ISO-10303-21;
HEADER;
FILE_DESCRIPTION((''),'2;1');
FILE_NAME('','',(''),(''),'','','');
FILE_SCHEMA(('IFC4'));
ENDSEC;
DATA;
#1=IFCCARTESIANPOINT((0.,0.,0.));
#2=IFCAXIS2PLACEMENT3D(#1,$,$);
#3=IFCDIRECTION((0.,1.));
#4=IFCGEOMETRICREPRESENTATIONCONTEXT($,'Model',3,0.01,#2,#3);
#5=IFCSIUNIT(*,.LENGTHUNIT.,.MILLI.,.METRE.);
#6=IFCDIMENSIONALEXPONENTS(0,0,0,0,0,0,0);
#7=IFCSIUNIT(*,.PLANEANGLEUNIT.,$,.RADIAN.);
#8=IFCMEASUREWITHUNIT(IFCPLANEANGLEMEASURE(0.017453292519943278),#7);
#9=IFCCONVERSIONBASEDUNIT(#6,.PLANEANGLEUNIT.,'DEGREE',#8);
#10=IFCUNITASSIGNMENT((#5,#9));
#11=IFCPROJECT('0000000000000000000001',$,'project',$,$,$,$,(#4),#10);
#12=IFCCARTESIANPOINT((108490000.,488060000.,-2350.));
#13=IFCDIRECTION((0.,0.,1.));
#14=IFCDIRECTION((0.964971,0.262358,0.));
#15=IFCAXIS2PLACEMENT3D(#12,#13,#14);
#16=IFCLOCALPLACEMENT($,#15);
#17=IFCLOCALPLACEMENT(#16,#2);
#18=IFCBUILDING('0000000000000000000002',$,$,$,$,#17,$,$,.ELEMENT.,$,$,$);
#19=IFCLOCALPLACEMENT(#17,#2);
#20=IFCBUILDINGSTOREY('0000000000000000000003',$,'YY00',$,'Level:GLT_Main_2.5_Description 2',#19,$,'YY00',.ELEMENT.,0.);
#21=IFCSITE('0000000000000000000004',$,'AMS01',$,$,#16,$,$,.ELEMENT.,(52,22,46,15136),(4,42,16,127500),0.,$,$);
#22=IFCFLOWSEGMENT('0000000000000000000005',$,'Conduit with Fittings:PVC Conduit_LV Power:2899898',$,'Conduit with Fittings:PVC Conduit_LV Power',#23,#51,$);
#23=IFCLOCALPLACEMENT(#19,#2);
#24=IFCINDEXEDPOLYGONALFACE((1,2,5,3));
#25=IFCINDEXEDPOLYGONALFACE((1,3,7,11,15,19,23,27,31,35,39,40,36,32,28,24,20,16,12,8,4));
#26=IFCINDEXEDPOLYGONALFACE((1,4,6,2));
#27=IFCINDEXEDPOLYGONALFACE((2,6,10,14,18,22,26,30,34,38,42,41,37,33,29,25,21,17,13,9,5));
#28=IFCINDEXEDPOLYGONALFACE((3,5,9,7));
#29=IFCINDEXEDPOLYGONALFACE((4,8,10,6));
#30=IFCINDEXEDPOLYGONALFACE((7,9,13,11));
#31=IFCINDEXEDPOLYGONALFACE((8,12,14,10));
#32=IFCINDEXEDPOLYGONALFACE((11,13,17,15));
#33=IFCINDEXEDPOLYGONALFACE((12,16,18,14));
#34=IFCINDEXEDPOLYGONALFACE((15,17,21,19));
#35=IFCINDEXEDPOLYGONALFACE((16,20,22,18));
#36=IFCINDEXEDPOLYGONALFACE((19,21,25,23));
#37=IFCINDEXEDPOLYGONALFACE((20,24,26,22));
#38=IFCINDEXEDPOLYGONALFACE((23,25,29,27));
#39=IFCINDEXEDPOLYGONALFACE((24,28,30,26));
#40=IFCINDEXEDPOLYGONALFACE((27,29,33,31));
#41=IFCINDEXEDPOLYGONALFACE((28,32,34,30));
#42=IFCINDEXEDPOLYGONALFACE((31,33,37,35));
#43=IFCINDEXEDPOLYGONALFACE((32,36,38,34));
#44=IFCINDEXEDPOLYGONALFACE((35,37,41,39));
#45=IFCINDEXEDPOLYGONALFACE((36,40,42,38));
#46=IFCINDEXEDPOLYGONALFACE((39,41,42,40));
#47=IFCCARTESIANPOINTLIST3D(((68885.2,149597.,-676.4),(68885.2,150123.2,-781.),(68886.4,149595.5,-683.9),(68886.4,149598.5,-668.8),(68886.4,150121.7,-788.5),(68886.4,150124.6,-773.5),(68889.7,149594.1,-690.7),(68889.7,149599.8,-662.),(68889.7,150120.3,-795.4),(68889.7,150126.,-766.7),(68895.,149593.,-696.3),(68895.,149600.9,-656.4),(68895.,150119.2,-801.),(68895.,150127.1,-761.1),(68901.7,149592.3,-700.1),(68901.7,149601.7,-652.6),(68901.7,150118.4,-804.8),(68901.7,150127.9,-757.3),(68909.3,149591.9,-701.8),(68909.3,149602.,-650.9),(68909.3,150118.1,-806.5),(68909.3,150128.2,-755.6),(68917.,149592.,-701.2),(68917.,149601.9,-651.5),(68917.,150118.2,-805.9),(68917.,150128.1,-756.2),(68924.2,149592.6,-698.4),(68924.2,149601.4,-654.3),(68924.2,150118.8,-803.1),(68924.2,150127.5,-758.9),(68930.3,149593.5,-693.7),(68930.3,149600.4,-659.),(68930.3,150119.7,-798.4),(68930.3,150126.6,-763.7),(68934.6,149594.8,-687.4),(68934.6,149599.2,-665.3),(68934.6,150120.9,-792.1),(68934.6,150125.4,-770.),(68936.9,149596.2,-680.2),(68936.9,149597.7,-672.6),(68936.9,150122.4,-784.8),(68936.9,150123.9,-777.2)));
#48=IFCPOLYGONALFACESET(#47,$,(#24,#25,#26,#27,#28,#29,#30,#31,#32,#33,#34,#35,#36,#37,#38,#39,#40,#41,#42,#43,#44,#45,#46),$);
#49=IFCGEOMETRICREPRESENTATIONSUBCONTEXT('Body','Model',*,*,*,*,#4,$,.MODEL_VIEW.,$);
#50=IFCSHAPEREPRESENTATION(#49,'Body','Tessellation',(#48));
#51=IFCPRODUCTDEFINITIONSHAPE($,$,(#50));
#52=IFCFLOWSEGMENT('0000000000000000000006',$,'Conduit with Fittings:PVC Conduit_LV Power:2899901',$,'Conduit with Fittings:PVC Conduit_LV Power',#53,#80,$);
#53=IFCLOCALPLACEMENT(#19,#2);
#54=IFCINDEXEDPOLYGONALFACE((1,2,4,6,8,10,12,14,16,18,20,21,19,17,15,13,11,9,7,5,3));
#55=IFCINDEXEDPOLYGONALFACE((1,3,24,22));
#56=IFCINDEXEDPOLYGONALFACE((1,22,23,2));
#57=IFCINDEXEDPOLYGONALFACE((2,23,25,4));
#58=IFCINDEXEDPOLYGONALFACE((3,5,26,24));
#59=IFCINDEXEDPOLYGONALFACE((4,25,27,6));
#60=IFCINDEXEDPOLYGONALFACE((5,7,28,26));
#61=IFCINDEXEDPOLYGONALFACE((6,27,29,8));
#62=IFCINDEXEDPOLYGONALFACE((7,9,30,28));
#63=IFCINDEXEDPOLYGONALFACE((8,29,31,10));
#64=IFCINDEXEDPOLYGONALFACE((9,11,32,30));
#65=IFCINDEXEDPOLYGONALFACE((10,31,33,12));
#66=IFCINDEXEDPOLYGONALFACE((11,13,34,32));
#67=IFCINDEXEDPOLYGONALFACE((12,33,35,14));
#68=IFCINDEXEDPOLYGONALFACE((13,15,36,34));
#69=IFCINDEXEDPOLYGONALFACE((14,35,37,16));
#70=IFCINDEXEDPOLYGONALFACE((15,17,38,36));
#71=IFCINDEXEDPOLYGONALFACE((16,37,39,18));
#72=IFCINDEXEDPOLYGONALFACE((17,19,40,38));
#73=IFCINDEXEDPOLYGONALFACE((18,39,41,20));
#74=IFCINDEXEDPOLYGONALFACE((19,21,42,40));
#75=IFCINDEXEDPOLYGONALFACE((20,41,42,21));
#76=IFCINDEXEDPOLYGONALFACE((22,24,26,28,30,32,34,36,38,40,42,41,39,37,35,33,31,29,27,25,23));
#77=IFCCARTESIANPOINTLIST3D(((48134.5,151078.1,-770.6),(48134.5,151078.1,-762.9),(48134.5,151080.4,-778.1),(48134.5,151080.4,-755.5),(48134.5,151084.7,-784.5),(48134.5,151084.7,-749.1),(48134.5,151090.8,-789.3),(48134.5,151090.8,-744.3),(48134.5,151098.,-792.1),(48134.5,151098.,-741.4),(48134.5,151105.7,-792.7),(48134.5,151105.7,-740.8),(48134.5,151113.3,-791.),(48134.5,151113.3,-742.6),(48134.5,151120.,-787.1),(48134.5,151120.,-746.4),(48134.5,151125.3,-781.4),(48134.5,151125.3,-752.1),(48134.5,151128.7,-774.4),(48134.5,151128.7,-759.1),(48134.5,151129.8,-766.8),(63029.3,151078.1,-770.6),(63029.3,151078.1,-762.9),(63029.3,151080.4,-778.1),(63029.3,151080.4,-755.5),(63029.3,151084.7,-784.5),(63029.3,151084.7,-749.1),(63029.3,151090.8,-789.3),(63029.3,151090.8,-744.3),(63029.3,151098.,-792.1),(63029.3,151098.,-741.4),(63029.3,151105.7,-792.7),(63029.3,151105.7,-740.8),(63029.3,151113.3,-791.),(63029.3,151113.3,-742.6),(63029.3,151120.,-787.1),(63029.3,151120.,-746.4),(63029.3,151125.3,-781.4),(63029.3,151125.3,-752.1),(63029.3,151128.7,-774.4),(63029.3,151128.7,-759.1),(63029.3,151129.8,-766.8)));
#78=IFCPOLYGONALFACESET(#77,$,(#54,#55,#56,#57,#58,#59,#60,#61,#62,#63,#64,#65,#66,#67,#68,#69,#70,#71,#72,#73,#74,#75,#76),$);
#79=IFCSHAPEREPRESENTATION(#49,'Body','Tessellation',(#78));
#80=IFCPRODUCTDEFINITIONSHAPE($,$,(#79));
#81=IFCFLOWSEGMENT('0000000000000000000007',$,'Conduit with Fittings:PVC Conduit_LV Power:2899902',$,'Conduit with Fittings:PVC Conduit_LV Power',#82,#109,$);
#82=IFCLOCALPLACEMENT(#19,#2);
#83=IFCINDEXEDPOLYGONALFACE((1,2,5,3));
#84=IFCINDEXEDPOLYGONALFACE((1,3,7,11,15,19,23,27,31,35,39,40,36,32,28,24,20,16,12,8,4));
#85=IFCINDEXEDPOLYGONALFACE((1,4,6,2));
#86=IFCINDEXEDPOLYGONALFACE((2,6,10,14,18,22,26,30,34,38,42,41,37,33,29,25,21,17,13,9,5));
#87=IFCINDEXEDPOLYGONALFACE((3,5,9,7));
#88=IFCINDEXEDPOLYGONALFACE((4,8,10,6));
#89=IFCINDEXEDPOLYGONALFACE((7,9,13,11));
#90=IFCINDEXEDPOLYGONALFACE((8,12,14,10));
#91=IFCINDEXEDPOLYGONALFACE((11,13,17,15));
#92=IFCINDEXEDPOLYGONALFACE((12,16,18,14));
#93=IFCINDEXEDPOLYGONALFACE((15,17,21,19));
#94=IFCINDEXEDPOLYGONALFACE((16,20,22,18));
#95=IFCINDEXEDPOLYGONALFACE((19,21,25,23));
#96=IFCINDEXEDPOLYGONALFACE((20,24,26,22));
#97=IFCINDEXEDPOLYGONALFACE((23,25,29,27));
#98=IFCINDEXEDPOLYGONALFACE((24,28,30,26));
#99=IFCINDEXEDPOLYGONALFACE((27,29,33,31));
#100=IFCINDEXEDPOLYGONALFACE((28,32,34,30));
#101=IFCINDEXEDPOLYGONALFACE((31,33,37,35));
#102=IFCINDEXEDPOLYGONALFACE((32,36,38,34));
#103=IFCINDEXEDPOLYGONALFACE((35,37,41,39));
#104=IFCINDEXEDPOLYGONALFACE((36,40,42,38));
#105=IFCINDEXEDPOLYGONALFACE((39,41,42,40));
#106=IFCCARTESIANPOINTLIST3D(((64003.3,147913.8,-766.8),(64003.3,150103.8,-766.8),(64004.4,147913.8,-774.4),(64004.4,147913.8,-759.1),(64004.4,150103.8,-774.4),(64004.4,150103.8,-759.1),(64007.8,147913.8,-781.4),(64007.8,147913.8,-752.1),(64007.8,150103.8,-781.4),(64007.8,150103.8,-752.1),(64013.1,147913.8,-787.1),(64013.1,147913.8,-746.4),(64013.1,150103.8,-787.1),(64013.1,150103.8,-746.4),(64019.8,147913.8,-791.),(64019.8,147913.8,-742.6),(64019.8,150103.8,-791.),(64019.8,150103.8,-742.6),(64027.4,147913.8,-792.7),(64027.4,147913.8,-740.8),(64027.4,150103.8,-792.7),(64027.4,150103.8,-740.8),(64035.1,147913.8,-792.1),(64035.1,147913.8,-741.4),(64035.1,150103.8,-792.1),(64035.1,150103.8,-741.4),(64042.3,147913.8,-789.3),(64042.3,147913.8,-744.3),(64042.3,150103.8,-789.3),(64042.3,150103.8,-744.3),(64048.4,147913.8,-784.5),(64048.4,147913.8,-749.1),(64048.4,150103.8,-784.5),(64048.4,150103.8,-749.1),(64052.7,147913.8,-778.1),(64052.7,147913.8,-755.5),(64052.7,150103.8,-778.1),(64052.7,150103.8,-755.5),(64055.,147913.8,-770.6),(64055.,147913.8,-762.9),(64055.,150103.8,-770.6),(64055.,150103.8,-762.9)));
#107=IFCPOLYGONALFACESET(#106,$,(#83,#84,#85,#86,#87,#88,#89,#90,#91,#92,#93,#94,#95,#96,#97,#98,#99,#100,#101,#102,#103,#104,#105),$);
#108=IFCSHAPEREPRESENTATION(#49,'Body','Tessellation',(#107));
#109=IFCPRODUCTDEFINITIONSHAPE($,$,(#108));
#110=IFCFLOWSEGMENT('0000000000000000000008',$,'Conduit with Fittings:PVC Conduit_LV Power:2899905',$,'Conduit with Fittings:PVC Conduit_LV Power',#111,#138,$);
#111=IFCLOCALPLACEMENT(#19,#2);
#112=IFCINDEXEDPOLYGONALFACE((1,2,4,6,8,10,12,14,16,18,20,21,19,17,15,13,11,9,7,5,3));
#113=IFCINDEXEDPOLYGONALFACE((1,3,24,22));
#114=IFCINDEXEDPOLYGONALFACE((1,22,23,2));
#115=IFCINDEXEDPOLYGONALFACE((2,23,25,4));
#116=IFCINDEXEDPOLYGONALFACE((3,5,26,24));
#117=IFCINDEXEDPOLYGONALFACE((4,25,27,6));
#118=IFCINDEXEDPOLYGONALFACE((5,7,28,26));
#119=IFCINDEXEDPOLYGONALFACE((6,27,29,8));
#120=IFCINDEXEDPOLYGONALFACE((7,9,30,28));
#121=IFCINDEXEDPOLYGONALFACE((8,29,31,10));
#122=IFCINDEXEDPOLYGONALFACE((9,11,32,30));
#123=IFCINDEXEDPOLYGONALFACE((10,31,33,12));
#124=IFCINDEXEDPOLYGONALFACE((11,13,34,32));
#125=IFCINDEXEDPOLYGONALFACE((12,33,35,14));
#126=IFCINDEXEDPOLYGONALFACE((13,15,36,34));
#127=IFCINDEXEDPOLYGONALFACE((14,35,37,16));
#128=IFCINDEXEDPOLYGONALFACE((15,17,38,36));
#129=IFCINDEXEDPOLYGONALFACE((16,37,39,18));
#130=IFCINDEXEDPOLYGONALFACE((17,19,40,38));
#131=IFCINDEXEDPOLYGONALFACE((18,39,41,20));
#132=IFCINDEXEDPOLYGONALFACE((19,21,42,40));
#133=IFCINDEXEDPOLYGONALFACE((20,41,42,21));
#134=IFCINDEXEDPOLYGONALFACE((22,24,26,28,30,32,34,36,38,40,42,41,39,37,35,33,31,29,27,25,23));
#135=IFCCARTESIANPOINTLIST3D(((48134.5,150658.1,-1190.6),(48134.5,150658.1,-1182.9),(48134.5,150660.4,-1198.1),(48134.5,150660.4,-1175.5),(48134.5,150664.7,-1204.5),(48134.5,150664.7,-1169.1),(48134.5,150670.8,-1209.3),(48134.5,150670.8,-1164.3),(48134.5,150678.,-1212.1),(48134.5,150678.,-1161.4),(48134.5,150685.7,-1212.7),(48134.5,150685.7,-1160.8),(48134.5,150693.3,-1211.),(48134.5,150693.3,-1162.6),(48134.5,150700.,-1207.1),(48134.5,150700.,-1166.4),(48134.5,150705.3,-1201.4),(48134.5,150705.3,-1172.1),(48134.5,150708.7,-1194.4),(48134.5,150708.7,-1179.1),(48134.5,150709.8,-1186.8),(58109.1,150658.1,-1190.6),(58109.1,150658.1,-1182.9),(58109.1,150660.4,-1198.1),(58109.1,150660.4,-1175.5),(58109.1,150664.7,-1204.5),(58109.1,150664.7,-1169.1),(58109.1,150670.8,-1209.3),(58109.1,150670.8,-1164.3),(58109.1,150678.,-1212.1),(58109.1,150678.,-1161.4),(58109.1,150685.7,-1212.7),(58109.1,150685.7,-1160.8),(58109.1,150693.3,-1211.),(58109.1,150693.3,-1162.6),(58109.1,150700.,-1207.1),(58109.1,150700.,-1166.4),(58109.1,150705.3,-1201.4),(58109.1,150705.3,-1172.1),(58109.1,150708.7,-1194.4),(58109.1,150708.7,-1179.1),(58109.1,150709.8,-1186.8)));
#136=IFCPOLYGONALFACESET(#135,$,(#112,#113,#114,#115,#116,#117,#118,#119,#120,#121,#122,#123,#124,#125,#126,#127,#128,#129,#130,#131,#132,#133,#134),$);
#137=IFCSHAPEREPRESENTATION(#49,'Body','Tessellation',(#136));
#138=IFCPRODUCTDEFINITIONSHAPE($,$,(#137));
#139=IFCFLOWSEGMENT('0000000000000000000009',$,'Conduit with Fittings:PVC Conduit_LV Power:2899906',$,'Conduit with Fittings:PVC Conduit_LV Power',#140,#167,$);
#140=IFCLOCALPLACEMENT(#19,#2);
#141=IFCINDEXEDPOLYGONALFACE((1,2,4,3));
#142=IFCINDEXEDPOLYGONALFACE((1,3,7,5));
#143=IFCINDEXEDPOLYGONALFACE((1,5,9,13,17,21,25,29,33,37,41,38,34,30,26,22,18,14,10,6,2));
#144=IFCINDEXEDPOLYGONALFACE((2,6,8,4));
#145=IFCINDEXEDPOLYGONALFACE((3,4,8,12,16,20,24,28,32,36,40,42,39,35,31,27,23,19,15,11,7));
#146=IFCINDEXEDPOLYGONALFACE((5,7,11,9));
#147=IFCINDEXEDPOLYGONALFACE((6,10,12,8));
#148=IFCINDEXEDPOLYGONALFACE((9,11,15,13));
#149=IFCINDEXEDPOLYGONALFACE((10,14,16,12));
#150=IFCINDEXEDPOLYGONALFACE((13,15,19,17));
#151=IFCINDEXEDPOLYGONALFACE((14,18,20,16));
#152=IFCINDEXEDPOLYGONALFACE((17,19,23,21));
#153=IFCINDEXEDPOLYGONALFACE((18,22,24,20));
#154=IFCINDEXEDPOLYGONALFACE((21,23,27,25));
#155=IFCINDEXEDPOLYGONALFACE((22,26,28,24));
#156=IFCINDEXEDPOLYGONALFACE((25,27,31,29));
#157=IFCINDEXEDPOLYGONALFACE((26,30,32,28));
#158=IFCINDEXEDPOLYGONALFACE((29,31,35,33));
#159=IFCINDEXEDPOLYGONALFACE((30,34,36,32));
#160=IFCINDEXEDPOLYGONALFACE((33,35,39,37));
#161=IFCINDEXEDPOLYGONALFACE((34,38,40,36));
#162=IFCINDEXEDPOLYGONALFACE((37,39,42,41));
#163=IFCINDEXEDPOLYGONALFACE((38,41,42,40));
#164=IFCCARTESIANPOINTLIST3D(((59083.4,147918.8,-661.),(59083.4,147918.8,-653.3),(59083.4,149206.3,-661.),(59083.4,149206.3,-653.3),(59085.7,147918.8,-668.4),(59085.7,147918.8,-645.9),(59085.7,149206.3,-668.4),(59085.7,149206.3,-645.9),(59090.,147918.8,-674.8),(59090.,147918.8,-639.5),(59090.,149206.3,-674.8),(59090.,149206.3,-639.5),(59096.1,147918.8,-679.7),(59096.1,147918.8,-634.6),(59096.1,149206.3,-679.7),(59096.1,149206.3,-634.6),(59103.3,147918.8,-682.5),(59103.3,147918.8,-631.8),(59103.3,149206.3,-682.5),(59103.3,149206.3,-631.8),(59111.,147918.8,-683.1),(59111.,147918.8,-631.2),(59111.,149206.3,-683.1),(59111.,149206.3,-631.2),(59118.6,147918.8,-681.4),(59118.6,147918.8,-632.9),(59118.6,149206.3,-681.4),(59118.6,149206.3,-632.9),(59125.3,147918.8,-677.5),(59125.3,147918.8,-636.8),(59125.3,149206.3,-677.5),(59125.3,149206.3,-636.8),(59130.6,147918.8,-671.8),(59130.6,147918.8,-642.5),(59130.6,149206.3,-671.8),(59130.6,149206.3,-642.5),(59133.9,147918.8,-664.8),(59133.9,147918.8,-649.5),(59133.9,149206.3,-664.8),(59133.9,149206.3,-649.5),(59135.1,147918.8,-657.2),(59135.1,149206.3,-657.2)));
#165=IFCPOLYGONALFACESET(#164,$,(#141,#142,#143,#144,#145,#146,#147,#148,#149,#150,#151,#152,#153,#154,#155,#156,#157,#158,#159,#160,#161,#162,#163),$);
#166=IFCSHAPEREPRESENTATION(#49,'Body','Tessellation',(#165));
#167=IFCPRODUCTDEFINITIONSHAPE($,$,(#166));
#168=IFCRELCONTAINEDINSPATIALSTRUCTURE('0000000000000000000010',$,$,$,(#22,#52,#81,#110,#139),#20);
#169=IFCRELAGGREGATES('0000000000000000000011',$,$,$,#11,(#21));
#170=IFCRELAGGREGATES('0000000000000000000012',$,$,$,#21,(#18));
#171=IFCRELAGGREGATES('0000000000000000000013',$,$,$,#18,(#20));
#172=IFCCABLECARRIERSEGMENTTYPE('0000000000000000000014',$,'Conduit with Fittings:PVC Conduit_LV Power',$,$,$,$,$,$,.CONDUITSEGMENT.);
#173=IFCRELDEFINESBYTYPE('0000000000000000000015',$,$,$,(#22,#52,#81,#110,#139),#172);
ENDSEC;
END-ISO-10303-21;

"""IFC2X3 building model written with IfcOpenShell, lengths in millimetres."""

from ifc_helpers import new_model, entity, si_unit, converted_unit, direction, frame, frame_2d, origin, origin_2d_with_axis, place, context, subcontext, project, spatial, circle, extrude, type_object, element, save


model = new_model("IFC2X3")

# Units and contexts
model_context = context("Model", 3, precision=0.01, world=origin(), true_north=direction((0.0, 1.0)))
body_context = subcontext(model_context, "Body", "Model", "MODEL_VIEW")
ifc_project = project(units=[si_unit("LENGTHUNIT", "METRE", prefix="MILLI"), converted_unit("PLANEANGLEUNIT", "DEGREE", entity("IfcPlaneAngleMeasure", 0.017453292519943278), si_unit("PLANEANGLEUNIT", "RADIAN"), dimensions=[0, 0, 0, 0, 0, 0, 0])], contexts=[model_context])

# Site, building, storey
site_placement = place(None, frame((108490000.0, 488060000.0, -2350.0), z_axis=(0.0, 0.0, 1.0), x_axis=(0.964971, 0.262358, 0.0)))
site = spatial("IfcSite", under=ifc_project, at=site_placement, Name="AMS01", CompositionType="ELEMENT", RefLatitude=(52, 22, 46, 15136), RefLongitude=(4, 42, 16, 127500), RefElevation=0.0)
building_placement = place(site_placement, origin())
building = spatial("IfcBuilding", under=site, at=building_placement, CompositionType="ELEMENT")
storey_placement = place(building_placement, origin())
storey = spatial("IfcBuildingStorey", under=building, at=storey_placement, Name="YY00", ObjectType="Level:GLT_Main_2.5_Description 2", LongName="YY00", CompositionType="ELEMENT", Elevation=0.0)

# Flow segments
cable_carrier_segment_type = type_object("IfcCableCarrierSegmentType", Name="Conduit with Fittings:PVC Conduit_LV Power", PredefinedType="CONDUITSEGMENT")
flow_segment_1_placement = place(storey_placement, origin())
element("IfcFlowSegment", 1, at=flow_segment_1_placement, inside=storey, type_object=cable_carrier_segment_type, Name="Conduit with Fittings:PVC Conduit_LV Power:2899898", ObjectType="Conduit with Fittings:PVC Conduit_LV Power", context=body_context, shape_type="SweptSolid", body=[
    extrude(circle(Radius=26.0, at=frame_2d((0.0, 0.0), x_axis=(1.0, 0.0))), frame((68911.2, 150123.2, -781.0), z_axis=(0.0, -0.980785, 0.19509), x_axis=(-1.0, 0.0, 0.0)), (0.0, 0.0, 1.0), 536.5),
])
flow_segment_2_placement = place(storey_placement, origin())
element("IfcFlowSegment", 2, at=flow_segment_2_placement, inside=storey, type_object=cable_carrier_segment_type, Name="Conduit with Fittings:PVC Conduit_LV Power:2899901", ObjectType="Conduit with Fittings:PVC Conduit_LV Power", context=body_context, shape_type="SweptSolid", body=[
    extrude(circle(Radius=26.0, at=frame_2d((0.0, 0.0), x_axis=(1.0, 0.0))), frame((48134.5, 151103.8, -766.8), z_axis=(1.0, 0.0, 0.0), x_axis=(0.0, 1.0, 0.0)), (0.0, 0.0, 1.0), 14894.8),
])
flow_segment_3_placement = place(storey_placement, origin())
element("IfcFlowSegment", 3, at=flow_segment_3_placement, inside=storey, type_object=cable_carrier_segment_type, Name="Conduit with Fittings:PVC Conduit_LV Power:2899902", ObjectType="Conduit with Fittings:PVC Conduit_LV Power", context=body_context, shape_type="SweptSolid", body=[
    extrude(circle(Radius=26.0, at=origin_2d_with_axis()), frame((64029.3, 147913.8, -766.8), z_axis=(0.0, 1.0, 0.0), x_axis=(-1.0, 0.0, 0.0)), (0.0, 0.0, 1.0), 2190.0),
])
flow_segment_4_placement = place(storey_placement, origin())
element("IfcFlowSegment", 4, at=flow_segment_4_placement, inside=storey, type_object=cable_carrier_segment_type, Name="Conduit with Fittings:PVC Conduit_LV Power:2899905", ObjectType="Conduit with Fittings:PVC Conduit_LV Power", context=body_context, shape_type="SweptSolid", body=[
    extrude(circle(Radius=26.0, at=frame_2d((0.0, 0.0), x_axis=(1.0, 0.0))), frame((48134.5, 150683.8, -1186.8), z_axis=(1.0, 0.0, 0.0), x_axis=(0.0, 1.0, 0.0)), (0.0, 0.0, 1.0), 9974.6),
])
flow_segment_5_placement = place(storey_placement, origin())
element("IfcFlowSegment", 5, at=flow_segment_5_placement, inside=storey, type_object=cable_carrier_segment_type, Name="Conduit with Fittings:PVC Conduit_LV Power:2899906", ObjectType="Conduit with Fittings:PVC Conduit_LV Power", context=body_context, shape_type="SweptSolid", body=[
    extrude(circle(Radius=26.0, at=origin_2d_with_axis()), frame((59109.1, 147918.8, -657.2), z_axis=(0.0, 1.0, 0.0), x_axis=(1.0, 0.0, 0.0)), (0.0, 0.0, 1.0), 1287.5),
])

save(model, "model.ifc")
